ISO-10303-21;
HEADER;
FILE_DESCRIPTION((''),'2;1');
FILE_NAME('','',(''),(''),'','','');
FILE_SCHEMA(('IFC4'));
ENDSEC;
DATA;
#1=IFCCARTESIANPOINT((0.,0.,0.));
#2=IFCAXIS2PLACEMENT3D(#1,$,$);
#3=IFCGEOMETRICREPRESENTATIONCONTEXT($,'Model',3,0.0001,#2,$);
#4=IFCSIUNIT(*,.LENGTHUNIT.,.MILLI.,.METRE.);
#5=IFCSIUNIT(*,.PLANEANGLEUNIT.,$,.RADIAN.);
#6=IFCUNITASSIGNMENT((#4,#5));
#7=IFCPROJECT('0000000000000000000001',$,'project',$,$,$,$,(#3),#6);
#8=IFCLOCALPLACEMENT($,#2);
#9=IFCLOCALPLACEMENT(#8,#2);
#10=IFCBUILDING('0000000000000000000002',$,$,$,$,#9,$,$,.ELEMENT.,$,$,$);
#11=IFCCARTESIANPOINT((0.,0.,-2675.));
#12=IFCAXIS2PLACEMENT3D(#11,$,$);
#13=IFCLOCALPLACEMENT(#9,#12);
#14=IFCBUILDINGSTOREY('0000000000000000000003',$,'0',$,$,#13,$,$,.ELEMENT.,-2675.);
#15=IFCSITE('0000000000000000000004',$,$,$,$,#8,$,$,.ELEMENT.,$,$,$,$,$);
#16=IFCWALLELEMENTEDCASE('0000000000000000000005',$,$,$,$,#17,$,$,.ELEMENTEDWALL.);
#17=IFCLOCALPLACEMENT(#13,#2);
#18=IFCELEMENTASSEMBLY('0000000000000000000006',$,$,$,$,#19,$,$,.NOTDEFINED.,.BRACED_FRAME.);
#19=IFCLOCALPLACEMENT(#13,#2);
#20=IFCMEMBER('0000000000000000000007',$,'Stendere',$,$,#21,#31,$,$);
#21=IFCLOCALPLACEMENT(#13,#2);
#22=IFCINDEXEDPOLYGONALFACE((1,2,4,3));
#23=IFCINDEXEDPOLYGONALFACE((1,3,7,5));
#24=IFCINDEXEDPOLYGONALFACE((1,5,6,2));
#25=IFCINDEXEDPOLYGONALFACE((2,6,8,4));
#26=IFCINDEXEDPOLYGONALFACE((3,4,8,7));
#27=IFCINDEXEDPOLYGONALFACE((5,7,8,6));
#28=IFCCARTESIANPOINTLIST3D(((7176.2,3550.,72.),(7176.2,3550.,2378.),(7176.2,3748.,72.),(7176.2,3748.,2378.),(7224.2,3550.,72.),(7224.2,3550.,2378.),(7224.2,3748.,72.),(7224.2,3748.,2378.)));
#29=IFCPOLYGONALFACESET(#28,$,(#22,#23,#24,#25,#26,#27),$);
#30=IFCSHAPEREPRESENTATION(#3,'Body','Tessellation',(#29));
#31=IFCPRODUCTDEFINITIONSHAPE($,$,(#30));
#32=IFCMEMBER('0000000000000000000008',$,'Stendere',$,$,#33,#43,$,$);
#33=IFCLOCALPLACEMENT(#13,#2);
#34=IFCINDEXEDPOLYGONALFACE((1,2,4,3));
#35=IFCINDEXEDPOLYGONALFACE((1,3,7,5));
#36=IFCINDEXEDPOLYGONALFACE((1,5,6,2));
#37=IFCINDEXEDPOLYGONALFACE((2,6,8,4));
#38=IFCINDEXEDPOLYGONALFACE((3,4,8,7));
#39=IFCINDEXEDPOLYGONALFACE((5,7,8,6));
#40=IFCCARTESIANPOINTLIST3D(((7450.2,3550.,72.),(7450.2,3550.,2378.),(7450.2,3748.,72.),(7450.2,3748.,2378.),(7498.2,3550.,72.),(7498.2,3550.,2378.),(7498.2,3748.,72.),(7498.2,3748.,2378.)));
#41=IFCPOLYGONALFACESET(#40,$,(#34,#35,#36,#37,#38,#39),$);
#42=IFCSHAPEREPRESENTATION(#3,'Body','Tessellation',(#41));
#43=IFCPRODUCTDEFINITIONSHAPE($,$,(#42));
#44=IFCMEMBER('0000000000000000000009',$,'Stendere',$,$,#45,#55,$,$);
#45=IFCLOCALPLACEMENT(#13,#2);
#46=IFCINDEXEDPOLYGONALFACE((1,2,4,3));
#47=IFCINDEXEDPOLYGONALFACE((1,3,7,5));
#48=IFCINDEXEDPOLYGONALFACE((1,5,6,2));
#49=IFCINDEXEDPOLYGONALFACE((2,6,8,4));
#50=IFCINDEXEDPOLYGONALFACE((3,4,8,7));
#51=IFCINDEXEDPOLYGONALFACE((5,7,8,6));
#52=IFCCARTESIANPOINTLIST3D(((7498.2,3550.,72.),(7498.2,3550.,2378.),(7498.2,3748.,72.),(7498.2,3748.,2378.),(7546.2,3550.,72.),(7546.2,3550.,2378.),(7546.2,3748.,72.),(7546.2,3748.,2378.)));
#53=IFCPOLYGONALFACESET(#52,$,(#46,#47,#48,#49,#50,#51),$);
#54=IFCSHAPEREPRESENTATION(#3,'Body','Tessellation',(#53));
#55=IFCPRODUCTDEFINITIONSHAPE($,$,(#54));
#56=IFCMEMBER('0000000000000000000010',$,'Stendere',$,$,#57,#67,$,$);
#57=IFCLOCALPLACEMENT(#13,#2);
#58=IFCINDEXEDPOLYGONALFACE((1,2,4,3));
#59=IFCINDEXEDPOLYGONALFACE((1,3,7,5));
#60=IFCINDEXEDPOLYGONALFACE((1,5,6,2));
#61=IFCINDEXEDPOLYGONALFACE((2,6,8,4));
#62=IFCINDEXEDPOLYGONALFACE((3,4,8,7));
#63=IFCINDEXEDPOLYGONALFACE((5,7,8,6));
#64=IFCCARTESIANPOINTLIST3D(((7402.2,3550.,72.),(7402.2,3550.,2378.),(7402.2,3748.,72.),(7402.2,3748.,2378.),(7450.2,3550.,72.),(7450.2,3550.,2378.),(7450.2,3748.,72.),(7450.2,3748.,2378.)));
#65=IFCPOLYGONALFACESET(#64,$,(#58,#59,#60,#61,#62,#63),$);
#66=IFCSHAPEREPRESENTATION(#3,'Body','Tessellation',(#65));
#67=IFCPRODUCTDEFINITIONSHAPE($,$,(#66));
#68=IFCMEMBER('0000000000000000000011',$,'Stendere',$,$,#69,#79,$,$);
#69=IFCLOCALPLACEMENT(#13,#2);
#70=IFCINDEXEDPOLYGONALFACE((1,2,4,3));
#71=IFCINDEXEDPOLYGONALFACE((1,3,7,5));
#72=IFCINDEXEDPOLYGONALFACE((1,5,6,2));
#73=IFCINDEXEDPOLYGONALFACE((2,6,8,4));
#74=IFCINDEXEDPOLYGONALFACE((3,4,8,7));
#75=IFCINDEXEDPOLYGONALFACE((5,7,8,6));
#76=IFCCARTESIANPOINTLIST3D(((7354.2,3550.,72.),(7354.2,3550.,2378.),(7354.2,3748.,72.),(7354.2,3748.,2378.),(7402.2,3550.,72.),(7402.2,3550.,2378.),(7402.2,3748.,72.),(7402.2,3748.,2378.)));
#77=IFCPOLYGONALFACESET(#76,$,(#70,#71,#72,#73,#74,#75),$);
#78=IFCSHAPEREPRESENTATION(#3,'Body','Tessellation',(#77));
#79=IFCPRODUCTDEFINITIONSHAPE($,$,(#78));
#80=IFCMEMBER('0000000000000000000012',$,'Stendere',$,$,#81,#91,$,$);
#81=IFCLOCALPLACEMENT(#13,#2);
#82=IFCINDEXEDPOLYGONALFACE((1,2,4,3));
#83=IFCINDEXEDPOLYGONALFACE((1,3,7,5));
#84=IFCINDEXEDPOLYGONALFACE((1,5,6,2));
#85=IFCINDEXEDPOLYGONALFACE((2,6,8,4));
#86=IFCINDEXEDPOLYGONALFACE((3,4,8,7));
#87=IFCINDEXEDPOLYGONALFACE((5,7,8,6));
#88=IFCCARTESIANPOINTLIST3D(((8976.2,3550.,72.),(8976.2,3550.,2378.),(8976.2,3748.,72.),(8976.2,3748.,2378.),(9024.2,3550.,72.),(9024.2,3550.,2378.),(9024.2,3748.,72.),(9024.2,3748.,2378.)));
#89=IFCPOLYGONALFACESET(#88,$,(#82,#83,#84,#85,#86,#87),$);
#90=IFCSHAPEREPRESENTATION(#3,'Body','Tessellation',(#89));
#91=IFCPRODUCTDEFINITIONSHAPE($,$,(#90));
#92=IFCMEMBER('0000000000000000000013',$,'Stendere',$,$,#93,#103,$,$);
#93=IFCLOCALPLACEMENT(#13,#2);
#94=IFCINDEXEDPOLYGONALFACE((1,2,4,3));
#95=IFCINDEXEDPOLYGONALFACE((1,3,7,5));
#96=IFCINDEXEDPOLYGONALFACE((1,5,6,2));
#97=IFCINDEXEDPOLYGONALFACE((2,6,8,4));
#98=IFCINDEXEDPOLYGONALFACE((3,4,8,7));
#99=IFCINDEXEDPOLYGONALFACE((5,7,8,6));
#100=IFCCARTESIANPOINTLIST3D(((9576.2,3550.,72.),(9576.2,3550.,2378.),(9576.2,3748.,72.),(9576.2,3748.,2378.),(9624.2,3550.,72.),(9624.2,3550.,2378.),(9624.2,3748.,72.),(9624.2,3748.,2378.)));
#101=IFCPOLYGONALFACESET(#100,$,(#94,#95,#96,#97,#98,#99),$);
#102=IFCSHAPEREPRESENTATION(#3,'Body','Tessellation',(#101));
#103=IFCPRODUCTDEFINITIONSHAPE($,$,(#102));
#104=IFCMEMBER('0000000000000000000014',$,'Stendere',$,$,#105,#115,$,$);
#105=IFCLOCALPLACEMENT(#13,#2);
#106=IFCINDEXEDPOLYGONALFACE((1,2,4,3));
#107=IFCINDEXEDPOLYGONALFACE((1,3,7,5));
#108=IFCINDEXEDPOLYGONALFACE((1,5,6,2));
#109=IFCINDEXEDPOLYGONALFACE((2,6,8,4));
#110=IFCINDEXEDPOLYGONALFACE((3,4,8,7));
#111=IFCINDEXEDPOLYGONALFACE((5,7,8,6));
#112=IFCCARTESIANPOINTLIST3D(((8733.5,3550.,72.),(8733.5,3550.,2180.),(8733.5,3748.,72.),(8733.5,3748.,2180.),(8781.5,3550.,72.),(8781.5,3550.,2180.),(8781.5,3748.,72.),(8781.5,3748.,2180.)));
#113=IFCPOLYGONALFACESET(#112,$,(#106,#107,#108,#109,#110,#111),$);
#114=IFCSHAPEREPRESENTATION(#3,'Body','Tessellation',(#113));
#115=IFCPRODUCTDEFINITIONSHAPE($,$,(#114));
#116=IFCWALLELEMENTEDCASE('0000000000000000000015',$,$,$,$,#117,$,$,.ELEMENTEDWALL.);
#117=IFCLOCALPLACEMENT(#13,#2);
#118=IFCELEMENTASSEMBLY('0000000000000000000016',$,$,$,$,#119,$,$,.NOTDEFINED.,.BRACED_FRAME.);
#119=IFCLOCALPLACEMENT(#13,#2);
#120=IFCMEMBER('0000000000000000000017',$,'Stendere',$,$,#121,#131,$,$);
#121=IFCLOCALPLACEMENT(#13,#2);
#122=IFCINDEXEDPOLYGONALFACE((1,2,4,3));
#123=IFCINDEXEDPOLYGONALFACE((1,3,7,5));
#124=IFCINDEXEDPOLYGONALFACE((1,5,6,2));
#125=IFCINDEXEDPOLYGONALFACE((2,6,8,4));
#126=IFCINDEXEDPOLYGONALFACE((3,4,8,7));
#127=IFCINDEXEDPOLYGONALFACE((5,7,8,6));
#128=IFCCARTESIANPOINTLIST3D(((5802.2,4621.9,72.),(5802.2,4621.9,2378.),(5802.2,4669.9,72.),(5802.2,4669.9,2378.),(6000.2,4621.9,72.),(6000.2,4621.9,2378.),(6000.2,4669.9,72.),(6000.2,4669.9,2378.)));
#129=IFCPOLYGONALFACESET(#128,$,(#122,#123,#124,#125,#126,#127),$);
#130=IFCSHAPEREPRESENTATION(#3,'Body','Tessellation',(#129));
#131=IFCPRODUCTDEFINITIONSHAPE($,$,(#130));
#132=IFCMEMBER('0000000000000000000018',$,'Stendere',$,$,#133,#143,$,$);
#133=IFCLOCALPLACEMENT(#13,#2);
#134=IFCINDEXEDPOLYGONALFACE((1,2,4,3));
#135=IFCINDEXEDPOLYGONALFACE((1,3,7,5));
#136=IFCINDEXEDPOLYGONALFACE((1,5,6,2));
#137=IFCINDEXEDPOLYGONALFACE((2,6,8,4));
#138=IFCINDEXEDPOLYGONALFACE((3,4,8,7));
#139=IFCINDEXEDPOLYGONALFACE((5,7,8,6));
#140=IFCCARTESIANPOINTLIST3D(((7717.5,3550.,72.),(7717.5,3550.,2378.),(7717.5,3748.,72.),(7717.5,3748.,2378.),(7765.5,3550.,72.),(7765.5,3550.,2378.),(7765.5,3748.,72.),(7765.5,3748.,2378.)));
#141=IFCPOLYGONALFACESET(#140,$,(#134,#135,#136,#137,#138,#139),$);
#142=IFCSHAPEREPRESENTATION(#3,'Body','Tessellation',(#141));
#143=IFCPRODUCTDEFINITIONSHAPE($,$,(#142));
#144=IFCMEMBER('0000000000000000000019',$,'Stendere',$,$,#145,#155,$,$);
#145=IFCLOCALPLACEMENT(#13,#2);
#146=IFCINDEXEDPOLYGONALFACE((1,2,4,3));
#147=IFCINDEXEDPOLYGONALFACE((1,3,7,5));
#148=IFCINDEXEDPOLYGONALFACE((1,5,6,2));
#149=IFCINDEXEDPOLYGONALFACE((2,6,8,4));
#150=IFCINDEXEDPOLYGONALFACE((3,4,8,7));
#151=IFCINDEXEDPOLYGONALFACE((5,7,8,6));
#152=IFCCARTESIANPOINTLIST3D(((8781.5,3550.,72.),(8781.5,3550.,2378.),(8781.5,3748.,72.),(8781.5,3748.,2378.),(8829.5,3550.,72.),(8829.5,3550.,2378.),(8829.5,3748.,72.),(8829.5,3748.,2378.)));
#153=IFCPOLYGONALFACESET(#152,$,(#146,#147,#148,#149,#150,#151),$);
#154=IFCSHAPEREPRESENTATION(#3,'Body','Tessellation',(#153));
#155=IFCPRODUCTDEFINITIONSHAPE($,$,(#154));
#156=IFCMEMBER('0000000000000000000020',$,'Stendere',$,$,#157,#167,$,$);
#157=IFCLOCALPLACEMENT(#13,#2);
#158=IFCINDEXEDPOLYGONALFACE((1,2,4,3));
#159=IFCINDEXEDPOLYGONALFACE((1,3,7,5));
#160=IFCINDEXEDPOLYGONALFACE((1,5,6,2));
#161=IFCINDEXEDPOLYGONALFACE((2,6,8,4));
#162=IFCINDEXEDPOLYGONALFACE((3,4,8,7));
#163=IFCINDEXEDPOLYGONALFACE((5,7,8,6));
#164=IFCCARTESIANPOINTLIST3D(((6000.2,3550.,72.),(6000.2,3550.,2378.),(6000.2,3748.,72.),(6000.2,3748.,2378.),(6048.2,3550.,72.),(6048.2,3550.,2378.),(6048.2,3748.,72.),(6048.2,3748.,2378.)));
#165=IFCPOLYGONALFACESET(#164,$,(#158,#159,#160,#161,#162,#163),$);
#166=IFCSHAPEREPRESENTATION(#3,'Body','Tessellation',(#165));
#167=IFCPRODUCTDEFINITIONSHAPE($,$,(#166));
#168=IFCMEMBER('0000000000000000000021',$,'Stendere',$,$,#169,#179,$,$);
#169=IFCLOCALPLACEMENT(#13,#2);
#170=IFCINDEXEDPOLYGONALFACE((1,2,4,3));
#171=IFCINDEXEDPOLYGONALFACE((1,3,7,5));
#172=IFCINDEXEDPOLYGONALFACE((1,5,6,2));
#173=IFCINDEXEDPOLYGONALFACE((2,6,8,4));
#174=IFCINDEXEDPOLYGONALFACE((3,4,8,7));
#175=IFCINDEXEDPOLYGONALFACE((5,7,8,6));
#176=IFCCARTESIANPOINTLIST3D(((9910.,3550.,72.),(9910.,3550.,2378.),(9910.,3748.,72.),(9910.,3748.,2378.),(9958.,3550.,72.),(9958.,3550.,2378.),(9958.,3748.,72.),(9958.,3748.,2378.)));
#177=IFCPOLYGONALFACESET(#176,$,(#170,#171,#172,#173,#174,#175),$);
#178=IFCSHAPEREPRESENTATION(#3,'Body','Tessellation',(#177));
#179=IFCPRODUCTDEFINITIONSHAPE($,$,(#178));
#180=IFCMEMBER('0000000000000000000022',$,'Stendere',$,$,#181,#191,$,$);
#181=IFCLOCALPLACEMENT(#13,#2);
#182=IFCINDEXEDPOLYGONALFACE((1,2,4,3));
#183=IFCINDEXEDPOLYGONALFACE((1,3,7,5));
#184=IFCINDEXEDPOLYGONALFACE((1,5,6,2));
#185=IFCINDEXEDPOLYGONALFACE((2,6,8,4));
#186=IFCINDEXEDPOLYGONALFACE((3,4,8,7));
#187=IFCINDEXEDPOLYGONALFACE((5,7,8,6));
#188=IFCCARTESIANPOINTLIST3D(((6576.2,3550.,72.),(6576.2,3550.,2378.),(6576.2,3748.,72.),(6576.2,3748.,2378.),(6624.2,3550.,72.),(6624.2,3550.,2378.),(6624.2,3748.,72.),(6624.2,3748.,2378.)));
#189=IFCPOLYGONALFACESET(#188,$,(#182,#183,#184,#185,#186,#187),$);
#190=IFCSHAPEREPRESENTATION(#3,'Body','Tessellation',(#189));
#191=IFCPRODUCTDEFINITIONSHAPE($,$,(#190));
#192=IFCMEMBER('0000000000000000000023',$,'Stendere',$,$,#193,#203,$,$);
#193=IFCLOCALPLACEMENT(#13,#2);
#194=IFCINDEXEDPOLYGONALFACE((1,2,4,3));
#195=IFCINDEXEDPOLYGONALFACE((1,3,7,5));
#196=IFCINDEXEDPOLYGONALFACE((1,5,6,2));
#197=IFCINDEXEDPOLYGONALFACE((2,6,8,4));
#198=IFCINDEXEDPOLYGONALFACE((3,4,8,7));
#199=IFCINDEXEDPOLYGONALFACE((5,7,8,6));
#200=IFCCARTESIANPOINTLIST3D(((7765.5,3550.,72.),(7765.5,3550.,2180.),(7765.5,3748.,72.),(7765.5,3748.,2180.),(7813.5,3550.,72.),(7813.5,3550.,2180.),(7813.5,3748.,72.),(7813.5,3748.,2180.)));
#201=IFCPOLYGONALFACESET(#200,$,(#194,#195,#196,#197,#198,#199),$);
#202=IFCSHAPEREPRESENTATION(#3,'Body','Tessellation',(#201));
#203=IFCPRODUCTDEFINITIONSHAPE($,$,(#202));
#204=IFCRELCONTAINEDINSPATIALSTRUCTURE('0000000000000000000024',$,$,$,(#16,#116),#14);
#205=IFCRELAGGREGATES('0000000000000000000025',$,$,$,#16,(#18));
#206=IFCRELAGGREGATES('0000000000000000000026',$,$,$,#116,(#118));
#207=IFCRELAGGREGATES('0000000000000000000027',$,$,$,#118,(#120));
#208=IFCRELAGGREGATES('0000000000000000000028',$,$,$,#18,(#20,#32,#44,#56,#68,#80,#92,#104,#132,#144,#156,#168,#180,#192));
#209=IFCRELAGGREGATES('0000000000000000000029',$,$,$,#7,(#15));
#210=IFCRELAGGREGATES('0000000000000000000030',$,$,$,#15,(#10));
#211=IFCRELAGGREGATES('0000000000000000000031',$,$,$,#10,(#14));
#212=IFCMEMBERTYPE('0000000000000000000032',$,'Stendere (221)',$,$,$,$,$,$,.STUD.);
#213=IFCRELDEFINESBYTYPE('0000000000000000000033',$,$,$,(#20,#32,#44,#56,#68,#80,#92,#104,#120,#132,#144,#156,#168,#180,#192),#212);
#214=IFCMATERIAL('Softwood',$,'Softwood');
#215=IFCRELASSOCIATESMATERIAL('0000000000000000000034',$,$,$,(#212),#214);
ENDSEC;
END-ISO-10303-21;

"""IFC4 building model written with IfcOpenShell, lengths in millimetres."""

from ifc_helpers import new_model, si_unit, frame, origin, place, context, project, spatial, rectangle, extrude, clip, halfspace, material, material_profile, profile_set, type_object, element, aggregate, save


model = new_model("IFC4")

# Units and contexts
model_context = context("Model", 3, precision=0.0001, world=origin())
ifc_project = project(units=[si_unit("LENGTHUNIT", "METRE", prefix="MILLI"), si_unit("PLANEANGLEUNIT", "RADIAN")], contexts=[model_context])

# Site, building, storey
site_placement = place(None, origin())
site = spatial("IfcSite", under=ifc_project, at=site_placement, CompositionType="ELEMENT")
building_placement = place(site_placement, origin())
building = spatial("IfcBuilding", under=site, at=building_placement, CompositionType="ELEMENT")
storey_placement = place(building_placement, frame((0.0, 0.0, -2675.0)))
storey = spatial("IfcBuildingStorey", under=building, at=storey_placement, Name="0", CompositionType="ELEMENT", Elevation=-2675.0)

# Wall, element assembly, members
wall_1_placement = place(storey_placement, frame((6000.2, 3748.0, 0.0), z_axis=(0.0, -1.0, 0.0)))
wall_1 = element("IfcWallElementedCase", 1, at=wall_1_placement, inside=storey, PredefinedType="ELEMENTEDWALL")
assembly_1_placement = place(wall_1_placement, origin())
assembly_1 = element("IfcElementAssembly", 2, at=assembly_1_placement, AssemblyPlace="NOTDEFINED", PredefinedType="BRACED_FRAME")
aggregate(wall_1, [assembly_1])
ifc_material_1 = material(Name="Softwood", Category="Softwood")
ifc_material_profile_1 = material_profile(ifc_material_1, rectangle(XDim=48.0, YDim=198.0), Name="Stendere (221)")
ifc_profile_set_1 = profile_set([ifc_material_profile_1])
member_type_1 = type_object("IfcMemberType", Name="Stendere (221)", PredefinedType="STUD", material=ifc_profile_set_1)
member_1_placement = place(assembly_1_placement, frame((1200.0, 72.0, 0.0), z_axis=(0.0, 1.0, 0.0), x_axis=(-1.0, 0.0, 0.0)))
member_1 = element("IfcMember", 3, at=member_1_placement, type_object=member_type_1, Name="Stendere", context=model_context, shape_type="SweptSolid", body=[
    extrude(rectangle(XDim=48.0, YDim=198.0), frame((0.0, 99.0, 0.0)), (0.0, 0.0, 1.0), 2306.0),
])
member_2_placement = place(assembly_1_placement, frame((1474.0, 72.0, 0.0), z_axis=(0.0, 1.0, 0.0), x_axis=(-1.0, 0.0, 0.0)))
member_2 = element("IfcMember", 4, at=member_2_placement, type_object=member_type_1, Name="Stendere", context=model_context, shape_type="SweptSolid", body=[
    extrude(rectangle(XDim=48.0, YDim=198.0), frame((0.0, 99.0, 0.0)), (0.0, 0.0, 1.0), 2306.0),
])
member_3_placement = place(assembly_1_placement, frame((1522.0, 72.0, 0.0), z_axis=(0.0, 1.0, 0.0), x_axis=(-1.0, 0.0, 0.0)))
member_3 = element("IfcMember", 5, at=member_3_placement, type_object=member_type_1, Name="Stendere", context=model_context, shape_type="Clipping", body=[
    clip(extrude(rectangle(XDim=48.0, YDim=198.0), frame((0.0, 99.0, 0.0)), (0.0, 0.0, 1.0), 2306.0), halfspace(frame((0.0, 99.0, 0.0)), True)),
])
member_4_placement = place(assembly_1_placement, frame((1426.0, 72.0, 0.0), z_axis=(0.0, 1.0, 0.0), x_axis=(-1.0, 0.0, 0.0)))
member_4 = element("IfcMember", 6, at=member_4_placement, type_object=member_type_1, Name="Stendere", context=model_context, shape_type="SweptSolid", body=[
    extrude(rectangle(XDim=48.0, YDim=198.0), frame((0.0, 99.0, 0.0)), (0.0, 0.0, 1.0), 2306.0),
])
member_5_placement = place(assembly_1_placement, frame((1378.0, 72.0, 0.0), z_axis=(0.0, 1.0, 0.0), x_axis=(-1.0, 0.0, 0.0)))
member_5 = element("IfcMember", 7, at=member_5_placement, type_object=member_type_1, Name="Stendere", context=model_context, shape_type="Clipping", body=[
    clip(extrude(rectangle(XDim=48.0, YDim=198.0), frame((0.0, 99.0, 0.0)), (0.0, 0.0, 1.0), 2306.0), halfspace(frame((0.0, 99.0, 0.0)), True)),
])
member_6_placement = place(assembly_1_placement, frame((3000.0, 72.0, 0.0), z_axis=(0.0, 1.0, 0.0), x_axis=(-1.0, 0.0, 0.0)))
member_6 = element("IfcMember", 8, at=member_6_placement, type_object=member_type_1, Name="Stendere", context=model_context, shape_type="SweptSolid", body=[
    extrude(rectangle(XDim=48.0, YDim=198.0), frame((0.0, 99.0, 0.0)), (0.0, 0.0, 1.0), 2306.0),
])
member_7_placement = place(assembly_1_placement, frame((3600.0, 72.0, 0.0), z_axis=(0.0, 1.0, 0.0), x_axis=(-1.0, 0.0, 0.0)))
member_7 = element("IfcMember", 9, at=member_7_placement, type_object=member_type_1, Name="Stendere", context=model_context, shape_type="SweptSolid", body=[
    extrude(rectangle(XDim=48.0, YDim=198.0), frame((0.0, 99.0, 0.0)), (0.0, 0.0, 1.0), 2306.0),
])
member_8_placement = place(assembly_1_placement, frame((2757.4, 72.0, 0.0), z_axis=(0.0, 1.0, 0.0), x_axis=(-1.0, 0.0, 0.0)))
member_8 = element("IfcMember", 10, at=member_8_placement, type_object=member_type_1, Name="Stendere", context=model_context, shape_type="SweptSolid", body=[
    extrude(rectangle(XDim=48.0, YDim=198.0), frame((0.0, 99.0, 0.0)), (0.0, 0.0, 1.0), 2108.0),
])

# Wall, element assembly, member
wall_2_placement = place(storey_placement, frame((6000.2, 7469.7, 0.0), z_axis=(-1.0, 0.0, 0.0), x_axis=(0.0, -1.0, 0.0)))
wall_2 = element("IfcWallElementedCase", 11, at=wall_2_placement, inside=storey, PredefinedType="ELEMENTEDWALL")
assembly_2_placement = place(wall_2_placement, origin())
assembly_2 = element("IfcElementAssembly", 12, at=assembly_2_placement, AssemblyPlace="NOTDEFINED", PredefinedType="BRACED_FRAME")
aggregate(wall_2, [assembly_2])
member_9_placement = place(assembly_2_placement, frame((2823.8, 72.0, 0.0), z_axis=(0.0, 1.0, 0.0), x_axis=(-1.0, 0.0, 0.0)))
member_9 = element("IfcMember", 13, at=member_9_placement, type_object=member_type_1, Name="Stendere", context=model_context, shape_type="SweptSolid", body=[
    extrude(rectangle(XDim=48.0, YDim=198.0), frame((0.0, 99.0, 0.0)), (0.0, 0.0, 1.0), 2306.0),
])
aggregate(assembly_2, [member_9])

# Members
member_10_placement = place(assembly_1_placement, frame((1741.4, 72.0, 0.0), z_axis=(0.0, 1.0, 0.0), x_axis=(-1.0, 0.0, 0.0)))
member_10 = element("IfcMember", 14, at=member_10_placement, type_object=member_type_1, Name="Stendere", context=model_context, shape_type="SweptSolid", body=[
    extrude(rectangle(XDim=48.0, YDim=198.0), frame((0.0, 99.0, 0.0)), (0.0, 0.0, 1.0), 2306.0),
])
member_11_placement = place(assembly_1_placement, frame((2805.4, 72.0, 0.0), z_axis=(0.0, 1.0, 0.0), x_axis=(-1.0, 0.0, 0.0)))
member_11 = element("IfcMember", 15, at=member_11_placement, type_object=member_type_1, Name="Stendere", context=model_context, shape_type="SweptSolid", body=[
    extrude(rectangle(XDim=48.0, YDim=198.0), frame((0.0, 99.0, 0.0)), (0.0, 0.0, 1.0), 2306.0),
])
member_12_placement = place(assembly_1_placement, frame((24.0, 72.0, 0.0), z_axis=(0.0, 1.0, 0.0), x_axis=(-1.0, 0.0, 0.0)))
member_12 = element("IfcMember", 16, at=member_12_placement, type_object=member_type_1, Name="Stendere", context=model_context, shape_type="SweptSolid", body=[
    extrude(rectangle(XDim=48.0, YDim=198.0), frame((0.0, 99.0, 0.0)), (0.0, 0.0, 1.0), 2306.0),
])
member_13_placement = place(assembly_1_placement, frame((3933.8, 72.0, 0.0), z_axis=(0.0, 1.0, 0.0), x_axis=(-1.0, 0.0, 0.0)))
member_13 = element("IfcMember", 17, at=member_13_placement, type_object=member_type_1, Name="Stendere", context=model_context, shape_type="SweptSolid", body=[
    extrude(rectangle(XDim=48.0, YDim=198.0), frame((0.0, 99.0, 0.0)), (0.0, 0.0, 1.0), 2306.0),
])
member_14_placement = place(assembly_1_placement, frame((600.0, 72.0, 0.0), z_axis=(0.0, 1.0, 0.0), x_axis=(-1.0, 0.0, 0.0)))
member_14 = element("IfcMember", 18, at=member_14_placement, type_object=member_type_1, Name="Stendere", context=model_context, shape_type="SweptSolid", body=[
    extrude(rectangle(XDim=48.0, YDim=198.0), frame((0.0, 99.0, 0.0)), (0.0, 0.0, 1.0), 2306.0),
])
member_15_placement = place(assembly_1_placement, frame((1789.4, 72.0, 0.0), z_axis=(0.0, 1.0, 0.0), x_axis=(-1.0, 0.0, 0.0)))
member_15 = element("IfcMember", 19, at=member_15_placement, type_object=member_type_1, Name="Stendere", context=model_context, shape_type="SweptSolid", body=[
    extrude(rectangle(XDim=48.0, YDim=198.0), frame((0.0, 99.0, 0.0)), (0.0, 0.0, 1.0), 2108.0),
])

aggregate(assembly_1, [member_1, member_2, member_3, member_4, member_5, member_6, member_7, member_8, member_10, member_11, member_12, member_13, member_14, member_15])

save(model, "model.ifc")
